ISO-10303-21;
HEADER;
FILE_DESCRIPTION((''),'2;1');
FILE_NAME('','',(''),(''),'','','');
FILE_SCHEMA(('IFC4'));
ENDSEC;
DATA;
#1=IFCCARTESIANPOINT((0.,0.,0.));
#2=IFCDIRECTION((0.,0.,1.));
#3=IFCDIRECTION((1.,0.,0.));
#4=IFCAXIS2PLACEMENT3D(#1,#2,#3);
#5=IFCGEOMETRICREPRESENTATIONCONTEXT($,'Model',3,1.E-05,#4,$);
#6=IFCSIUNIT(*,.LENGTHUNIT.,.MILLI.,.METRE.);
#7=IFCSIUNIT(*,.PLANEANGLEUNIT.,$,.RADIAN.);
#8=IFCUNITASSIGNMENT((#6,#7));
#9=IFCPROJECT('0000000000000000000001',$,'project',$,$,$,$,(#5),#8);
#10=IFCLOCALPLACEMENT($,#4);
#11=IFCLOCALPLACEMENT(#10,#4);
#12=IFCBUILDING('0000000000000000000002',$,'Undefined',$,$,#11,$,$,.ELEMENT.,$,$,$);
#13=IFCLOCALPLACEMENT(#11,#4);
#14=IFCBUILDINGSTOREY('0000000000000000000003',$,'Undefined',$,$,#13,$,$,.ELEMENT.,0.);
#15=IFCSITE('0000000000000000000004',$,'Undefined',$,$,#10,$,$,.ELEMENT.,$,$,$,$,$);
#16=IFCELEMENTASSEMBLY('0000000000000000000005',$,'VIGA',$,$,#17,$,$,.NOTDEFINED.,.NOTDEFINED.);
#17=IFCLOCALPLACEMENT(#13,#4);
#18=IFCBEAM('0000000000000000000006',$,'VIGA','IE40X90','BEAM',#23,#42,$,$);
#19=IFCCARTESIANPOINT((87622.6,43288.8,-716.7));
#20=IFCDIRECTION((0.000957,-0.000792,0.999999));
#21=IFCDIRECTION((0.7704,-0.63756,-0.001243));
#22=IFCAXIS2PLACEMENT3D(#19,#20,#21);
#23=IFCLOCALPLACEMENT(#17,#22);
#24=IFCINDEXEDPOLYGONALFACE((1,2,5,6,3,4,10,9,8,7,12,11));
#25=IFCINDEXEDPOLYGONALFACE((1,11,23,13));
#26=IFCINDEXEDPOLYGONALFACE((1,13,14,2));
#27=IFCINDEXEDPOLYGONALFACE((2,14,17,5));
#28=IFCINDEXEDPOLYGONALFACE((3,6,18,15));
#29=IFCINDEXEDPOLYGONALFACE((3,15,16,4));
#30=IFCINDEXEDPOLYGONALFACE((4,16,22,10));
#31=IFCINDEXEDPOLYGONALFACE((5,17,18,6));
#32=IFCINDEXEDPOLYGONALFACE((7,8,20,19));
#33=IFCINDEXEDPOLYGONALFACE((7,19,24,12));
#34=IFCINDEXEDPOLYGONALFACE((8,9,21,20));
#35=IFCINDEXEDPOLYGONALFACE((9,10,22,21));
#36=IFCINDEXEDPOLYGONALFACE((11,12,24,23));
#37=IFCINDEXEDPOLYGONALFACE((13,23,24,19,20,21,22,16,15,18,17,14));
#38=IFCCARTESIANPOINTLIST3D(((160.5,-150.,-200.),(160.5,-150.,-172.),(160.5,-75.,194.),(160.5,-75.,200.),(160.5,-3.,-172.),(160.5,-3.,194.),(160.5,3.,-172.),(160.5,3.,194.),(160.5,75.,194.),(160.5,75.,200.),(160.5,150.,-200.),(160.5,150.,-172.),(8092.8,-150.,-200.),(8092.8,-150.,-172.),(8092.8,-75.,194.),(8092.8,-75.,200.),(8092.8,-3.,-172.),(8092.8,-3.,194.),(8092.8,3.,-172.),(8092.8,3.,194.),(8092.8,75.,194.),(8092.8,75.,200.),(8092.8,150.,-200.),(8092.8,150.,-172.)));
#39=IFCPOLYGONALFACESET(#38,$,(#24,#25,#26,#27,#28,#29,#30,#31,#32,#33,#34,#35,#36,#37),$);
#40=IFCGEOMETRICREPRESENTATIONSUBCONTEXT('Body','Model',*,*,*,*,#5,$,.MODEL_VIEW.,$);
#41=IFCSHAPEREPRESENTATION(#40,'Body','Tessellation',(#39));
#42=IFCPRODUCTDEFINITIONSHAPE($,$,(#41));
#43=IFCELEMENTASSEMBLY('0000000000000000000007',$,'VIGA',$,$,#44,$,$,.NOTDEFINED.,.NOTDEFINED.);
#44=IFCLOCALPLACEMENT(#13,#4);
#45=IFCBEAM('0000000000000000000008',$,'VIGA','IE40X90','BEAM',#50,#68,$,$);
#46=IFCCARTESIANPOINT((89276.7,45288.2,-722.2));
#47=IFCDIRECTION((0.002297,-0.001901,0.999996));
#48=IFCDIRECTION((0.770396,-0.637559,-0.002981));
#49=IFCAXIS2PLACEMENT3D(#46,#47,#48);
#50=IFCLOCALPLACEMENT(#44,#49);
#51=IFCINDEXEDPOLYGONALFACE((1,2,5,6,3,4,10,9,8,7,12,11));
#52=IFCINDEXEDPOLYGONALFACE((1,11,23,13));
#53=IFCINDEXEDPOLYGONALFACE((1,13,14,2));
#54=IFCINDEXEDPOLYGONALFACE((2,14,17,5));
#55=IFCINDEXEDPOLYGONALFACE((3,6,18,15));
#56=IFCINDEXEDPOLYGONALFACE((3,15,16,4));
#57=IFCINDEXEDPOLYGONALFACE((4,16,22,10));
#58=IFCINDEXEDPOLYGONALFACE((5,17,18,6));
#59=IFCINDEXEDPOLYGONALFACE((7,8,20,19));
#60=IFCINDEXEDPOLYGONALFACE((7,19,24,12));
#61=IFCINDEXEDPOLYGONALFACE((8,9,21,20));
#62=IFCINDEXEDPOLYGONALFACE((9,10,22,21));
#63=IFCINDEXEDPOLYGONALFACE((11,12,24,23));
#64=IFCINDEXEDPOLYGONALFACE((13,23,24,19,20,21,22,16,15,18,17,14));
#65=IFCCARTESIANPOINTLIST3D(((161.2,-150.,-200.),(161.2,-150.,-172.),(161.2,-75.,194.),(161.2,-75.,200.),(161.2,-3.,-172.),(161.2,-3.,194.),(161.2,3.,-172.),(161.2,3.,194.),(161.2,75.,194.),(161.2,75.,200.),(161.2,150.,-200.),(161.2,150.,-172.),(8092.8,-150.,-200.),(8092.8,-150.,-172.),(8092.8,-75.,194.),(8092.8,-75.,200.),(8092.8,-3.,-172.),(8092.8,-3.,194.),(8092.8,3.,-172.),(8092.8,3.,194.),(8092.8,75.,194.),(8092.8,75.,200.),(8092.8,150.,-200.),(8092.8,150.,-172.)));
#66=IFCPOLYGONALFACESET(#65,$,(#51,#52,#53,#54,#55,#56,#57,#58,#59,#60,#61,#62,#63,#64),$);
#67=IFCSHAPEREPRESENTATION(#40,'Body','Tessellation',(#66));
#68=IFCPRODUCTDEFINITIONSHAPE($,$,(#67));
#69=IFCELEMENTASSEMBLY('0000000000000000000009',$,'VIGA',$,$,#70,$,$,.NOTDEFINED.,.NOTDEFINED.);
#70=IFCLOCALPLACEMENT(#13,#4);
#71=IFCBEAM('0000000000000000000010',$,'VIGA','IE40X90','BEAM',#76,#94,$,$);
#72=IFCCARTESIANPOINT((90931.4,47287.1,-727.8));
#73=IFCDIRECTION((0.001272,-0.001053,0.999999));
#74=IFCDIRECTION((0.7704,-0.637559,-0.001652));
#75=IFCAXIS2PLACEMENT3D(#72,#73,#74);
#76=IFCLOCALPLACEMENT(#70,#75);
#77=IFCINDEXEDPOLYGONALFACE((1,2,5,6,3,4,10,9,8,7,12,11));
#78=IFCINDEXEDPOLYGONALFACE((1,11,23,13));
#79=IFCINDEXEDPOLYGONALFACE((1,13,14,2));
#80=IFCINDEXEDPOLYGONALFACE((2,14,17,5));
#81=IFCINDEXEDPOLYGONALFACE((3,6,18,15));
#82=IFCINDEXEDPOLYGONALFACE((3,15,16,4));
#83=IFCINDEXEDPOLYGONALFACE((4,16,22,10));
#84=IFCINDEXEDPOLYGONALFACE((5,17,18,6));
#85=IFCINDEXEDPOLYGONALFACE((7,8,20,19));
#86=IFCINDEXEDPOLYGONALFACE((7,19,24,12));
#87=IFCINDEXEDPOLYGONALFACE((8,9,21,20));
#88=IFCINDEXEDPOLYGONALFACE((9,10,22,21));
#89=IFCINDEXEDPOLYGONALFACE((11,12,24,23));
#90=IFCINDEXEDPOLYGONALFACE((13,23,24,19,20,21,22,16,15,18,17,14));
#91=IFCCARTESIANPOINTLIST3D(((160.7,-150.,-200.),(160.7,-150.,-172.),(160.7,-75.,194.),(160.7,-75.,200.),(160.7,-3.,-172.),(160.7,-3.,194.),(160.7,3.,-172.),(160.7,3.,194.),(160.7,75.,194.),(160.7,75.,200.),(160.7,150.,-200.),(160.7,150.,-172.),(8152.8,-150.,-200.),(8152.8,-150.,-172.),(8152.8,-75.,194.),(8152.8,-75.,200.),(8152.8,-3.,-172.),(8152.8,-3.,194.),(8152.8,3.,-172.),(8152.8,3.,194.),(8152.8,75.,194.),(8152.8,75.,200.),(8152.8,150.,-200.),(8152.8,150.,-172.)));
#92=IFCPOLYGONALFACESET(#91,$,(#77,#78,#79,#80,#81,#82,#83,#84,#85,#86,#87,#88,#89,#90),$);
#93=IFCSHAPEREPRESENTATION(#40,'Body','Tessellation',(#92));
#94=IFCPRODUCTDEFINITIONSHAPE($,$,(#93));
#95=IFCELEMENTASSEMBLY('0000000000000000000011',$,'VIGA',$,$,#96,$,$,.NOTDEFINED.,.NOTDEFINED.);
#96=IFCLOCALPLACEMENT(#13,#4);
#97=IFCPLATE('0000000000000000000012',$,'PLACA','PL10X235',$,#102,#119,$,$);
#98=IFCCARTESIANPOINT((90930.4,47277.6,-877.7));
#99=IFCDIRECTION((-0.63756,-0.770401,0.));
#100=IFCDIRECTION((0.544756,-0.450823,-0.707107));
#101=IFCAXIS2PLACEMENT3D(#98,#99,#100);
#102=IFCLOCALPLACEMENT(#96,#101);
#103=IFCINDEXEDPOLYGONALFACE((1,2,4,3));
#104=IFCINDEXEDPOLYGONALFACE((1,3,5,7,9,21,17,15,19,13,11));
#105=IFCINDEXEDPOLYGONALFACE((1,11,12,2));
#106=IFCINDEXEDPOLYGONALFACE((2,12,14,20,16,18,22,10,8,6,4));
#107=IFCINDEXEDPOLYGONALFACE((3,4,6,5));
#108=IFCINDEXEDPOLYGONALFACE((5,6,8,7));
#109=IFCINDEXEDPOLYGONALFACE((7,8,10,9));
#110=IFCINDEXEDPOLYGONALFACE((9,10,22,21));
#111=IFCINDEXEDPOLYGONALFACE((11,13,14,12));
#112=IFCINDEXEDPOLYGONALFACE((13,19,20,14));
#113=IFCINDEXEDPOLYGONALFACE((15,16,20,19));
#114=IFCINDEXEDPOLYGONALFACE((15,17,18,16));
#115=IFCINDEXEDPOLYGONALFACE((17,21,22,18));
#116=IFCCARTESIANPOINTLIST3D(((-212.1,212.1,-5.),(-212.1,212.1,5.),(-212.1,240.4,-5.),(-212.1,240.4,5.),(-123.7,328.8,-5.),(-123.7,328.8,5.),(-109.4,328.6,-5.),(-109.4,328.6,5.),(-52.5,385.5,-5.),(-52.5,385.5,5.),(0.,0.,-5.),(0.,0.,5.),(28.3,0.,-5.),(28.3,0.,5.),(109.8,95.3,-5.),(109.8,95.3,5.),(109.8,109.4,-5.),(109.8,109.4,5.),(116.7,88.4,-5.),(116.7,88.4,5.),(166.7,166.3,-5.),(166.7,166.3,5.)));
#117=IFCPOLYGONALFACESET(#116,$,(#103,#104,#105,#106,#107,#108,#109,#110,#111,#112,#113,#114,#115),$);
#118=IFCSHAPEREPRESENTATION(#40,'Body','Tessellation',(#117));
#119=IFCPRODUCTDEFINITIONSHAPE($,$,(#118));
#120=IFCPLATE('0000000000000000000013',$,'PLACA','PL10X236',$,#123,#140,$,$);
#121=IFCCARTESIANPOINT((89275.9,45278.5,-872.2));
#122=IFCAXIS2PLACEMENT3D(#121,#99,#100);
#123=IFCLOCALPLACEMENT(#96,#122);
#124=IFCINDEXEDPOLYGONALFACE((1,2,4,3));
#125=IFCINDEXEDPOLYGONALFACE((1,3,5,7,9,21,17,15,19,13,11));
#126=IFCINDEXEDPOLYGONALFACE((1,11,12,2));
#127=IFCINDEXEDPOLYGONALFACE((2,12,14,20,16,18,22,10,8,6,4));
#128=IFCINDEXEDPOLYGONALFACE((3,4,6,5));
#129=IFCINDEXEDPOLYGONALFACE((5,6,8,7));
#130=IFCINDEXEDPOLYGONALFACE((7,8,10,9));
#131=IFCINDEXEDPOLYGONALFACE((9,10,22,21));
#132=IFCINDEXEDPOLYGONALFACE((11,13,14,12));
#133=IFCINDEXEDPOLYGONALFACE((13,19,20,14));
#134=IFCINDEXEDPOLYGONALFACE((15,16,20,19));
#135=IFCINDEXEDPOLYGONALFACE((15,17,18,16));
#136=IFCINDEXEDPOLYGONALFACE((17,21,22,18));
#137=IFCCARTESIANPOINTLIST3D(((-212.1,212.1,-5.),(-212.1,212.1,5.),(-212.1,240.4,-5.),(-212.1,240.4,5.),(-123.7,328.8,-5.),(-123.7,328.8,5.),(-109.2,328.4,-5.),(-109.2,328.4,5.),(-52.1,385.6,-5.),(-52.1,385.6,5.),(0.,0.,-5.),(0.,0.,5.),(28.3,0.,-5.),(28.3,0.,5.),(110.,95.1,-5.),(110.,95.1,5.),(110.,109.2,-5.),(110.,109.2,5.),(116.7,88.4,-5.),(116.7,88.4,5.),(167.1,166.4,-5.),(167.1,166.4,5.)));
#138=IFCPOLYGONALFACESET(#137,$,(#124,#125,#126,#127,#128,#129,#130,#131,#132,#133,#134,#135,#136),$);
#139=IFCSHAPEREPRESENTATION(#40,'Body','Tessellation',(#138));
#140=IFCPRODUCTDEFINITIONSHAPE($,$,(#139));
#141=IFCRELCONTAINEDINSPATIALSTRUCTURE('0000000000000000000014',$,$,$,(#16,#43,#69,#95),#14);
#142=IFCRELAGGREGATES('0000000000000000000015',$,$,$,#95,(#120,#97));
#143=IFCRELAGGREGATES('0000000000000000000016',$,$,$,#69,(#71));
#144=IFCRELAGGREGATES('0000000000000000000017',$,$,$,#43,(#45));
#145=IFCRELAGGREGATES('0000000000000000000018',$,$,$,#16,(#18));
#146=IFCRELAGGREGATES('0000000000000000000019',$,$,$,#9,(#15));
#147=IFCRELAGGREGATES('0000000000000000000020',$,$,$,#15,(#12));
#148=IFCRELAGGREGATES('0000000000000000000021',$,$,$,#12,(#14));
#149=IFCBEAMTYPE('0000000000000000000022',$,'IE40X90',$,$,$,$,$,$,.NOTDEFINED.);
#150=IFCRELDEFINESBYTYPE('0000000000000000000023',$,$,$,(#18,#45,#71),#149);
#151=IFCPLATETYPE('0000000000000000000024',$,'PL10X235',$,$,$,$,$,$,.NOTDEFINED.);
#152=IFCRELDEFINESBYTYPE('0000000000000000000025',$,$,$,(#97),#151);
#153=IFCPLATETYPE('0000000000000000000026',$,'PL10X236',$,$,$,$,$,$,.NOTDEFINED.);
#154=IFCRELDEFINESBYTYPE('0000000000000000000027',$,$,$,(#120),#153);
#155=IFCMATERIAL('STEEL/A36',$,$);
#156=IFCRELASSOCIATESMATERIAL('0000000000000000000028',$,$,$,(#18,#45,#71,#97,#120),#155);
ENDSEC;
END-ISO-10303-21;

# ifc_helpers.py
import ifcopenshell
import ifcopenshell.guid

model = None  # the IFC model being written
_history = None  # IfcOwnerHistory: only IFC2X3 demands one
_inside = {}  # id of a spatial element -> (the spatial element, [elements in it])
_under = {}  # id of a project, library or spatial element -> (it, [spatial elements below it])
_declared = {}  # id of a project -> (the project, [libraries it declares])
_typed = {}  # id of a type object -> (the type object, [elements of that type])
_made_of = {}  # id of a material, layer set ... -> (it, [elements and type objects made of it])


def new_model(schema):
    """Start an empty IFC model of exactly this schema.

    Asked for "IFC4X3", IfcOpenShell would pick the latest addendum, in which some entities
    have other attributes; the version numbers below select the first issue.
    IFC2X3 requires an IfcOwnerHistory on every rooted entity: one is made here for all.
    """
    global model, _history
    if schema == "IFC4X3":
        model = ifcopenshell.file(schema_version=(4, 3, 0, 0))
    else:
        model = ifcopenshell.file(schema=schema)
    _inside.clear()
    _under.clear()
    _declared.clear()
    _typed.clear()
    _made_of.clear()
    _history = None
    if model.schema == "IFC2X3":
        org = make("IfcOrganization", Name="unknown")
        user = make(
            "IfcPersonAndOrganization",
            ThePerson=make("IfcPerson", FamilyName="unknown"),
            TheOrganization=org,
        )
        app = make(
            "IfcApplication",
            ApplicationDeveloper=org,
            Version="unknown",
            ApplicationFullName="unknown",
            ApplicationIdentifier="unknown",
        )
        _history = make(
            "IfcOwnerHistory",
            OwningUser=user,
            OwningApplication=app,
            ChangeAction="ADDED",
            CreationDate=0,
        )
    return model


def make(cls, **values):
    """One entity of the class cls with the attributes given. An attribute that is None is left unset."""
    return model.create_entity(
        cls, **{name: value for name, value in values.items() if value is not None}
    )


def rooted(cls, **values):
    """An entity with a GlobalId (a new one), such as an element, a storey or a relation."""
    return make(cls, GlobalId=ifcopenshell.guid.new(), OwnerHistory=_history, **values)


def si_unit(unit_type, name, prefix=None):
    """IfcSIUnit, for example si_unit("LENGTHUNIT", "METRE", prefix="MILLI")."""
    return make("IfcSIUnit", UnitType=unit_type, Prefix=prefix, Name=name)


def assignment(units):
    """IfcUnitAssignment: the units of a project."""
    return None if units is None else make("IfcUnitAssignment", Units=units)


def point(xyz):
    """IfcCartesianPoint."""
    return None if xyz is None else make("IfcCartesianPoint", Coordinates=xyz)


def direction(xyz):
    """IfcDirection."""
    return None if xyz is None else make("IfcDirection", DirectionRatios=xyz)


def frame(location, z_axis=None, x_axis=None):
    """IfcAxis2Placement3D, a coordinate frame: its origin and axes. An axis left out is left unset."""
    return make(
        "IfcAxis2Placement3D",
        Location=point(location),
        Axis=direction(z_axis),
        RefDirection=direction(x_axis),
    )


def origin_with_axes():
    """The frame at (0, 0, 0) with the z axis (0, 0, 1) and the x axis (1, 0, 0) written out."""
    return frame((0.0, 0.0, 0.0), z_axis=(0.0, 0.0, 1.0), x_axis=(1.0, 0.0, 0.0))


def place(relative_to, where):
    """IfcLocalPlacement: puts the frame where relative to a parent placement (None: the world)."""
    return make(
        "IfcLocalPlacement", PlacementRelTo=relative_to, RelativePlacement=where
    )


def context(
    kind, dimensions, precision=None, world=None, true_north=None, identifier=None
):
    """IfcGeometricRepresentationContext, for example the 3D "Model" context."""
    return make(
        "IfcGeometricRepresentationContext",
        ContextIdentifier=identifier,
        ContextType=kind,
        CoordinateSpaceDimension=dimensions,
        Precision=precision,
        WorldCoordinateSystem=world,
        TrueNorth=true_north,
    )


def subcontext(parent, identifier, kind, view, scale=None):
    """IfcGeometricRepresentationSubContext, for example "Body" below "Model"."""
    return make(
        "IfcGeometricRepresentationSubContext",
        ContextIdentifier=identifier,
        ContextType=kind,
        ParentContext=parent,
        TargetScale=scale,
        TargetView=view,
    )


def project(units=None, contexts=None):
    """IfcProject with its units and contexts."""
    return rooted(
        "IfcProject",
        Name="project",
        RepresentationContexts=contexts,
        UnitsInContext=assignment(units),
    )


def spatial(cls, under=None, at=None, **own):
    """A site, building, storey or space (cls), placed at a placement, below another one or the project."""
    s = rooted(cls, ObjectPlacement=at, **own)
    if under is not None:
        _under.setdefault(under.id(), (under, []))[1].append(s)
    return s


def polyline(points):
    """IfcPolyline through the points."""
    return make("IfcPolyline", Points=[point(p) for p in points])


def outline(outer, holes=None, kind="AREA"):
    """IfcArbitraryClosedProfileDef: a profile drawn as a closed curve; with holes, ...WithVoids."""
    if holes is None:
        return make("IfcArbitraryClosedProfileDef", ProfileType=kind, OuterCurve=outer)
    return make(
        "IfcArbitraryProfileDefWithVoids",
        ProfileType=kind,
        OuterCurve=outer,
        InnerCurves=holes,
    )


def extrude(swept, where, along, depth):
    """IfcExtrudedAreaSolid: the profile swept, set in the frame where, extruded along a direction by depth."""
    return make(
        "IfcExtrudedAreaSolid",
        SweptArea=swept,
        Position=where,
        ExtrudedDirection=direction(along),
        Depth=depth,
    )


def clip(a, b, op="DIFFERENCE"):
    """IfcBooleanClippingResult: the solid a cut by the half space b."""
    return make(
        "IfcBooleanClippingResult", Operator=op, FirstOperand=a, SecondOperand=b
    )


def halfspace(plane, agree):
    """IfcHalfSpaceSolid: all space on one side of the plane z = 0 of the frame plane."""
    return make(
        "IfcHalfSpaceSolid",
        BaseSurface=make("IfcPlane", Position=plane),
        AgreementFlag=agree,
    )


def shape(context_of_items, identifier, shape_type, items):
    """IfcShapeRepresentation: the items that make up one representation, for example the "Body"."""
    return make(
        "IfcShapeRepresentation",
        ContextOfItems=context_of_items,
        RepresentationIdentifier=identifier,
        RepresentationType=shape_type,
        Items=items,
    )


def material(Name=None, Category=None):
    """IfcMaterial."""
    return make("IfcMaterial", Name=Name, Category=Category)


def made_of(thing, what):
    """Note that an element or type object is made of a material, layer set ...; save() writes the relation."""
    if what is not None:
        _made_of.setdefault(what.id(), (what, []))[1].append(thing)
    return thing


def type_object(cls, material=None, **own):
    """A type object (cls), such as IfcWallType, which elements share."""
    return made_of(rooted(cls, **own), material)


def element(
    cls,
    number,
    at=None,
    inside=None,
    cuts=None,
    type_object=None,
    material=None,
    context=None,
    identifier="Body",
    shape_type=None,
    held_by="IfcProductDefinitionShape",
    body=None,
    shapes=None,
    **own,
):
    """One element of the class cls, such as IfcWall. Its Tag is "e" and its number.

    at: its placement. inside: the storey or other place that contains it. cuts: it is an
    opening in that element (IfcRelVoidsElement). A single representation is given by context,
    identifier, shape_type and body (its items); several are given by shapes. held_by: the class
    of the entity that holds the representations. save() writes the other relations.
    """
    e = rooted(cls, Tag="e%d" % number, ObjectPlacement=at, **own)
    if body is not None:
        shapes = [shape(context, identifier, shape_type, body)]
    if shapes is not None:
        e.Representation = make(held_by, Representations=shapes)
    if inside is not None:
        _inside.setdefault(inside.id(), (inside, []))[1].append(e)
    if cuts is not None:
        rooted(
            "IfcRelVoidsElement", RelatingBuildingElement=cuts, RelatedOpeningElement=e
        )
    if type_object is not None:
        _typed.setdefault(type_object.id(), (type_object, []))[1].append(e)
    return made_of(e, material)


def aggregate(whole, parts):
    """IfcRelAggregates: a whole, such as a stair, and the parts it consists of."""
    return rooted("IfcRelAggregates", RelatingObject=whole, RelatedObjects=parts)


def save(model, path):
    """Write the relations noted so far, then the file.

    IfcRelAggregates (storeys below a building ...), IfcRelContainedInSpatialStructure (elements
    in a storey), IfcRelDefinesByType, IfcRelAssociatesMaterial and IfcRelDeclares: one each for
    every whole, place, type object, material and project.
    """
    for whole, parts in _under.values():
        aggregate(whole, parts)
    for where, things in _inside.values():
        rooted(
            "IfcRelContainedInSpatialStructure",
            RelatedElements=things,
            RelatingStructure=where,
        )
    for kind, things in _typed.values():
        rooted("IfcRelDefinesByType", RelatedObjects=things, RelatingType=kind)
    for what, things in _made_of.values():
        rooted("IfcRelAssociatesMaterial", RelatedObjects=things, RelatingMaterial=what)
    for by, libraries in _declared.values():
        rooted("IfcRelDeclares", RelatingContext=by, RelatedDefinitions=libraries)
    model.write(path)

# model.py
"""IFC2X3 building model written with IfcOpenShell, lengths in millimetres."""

from ifc_helpers import new_model, si_unit, frame, origin_with_axes, place, context, subcontext, project, spatial, polyline, outline, extrude, clip, halfspace, material, type_object, element, aggregate, save


model = new_model("IFC2X3")

# Units and contexts
model_context = context("Model", 3, precision=1e-05, world=origin_with_axes())
body_context = subcontext(model_context, "Body", "Model", "MODEL_VIEW")
ifc_project = project(units=[si_unit("LENGTHUNIT", "METRE", prefix="MILLI"), si_unit("PLANEANGLEUNIT", "RADIAN")], contexts=[model_context])

# Site, building, storey
site_placement = place(None, origin_with_axes())
site = spatial("IfcSite", under=ifc_project, at=site_placement, Name="Undefined", CompositionType="ELEMENT")
building_placement = place(site_placement, origin_with_axes())
building = spatial("IfcBuilding", under=site, at=building_placement, Name="Undefined", CompositionType="ELEMENT")
storey_placement = place(building_placement, origin_with_axes())
storey = spatial("IfcBuildingStorey", under=building, at=storey_placement, Name="Undefined", CompositionType="ELEMENT", Elevation=0.0)

# Element assemblies, beams
ifc_material_1 = material(Name="STEEL/A36")
assembly_1_placement = place(storey_placement, origin_with_axes())
assembly_1 = element("IfcElementAssembly", 1, at=assembly_1_placement, inside=storey, Name="VIGA", AssemblyPlace="NOTDEFINED", PredefinedType="NOTDEFINED")
beam_type_1 = type_object("IfcBeamType", Name="IE40X90", PredefinedType="NOTDEFINED")
beam_1_placement = place(assembly_1_placement, frame((87622.6, 43288.8, -716.7), z_axis=(0.000957, -0.000792, 0.999999), x_axis=(0.7704, -0.63756, -0.001243)))
beam_1 = element("IfcBeam", 2, at=beam_1_placement, type_object=beam_type_1, material=ifc_material_1, Name="VIGA", Description="IE40X90", ObjectType="BEAM", context=body_context, shape_type="Clipping", body=[
    clip(clip(extrude(outline(polyline([(3.0, 194.0), (3.0, -172.0), (150.0, -172.0), (150.0, -200.0), (-150.0, -200.0), (-150.0, -172.0), (-3.0, -172.0), (-3.0, 194.0), (-75.0, 194.0), (-75.0, 200.0), (75.0, 200.0), (75.0, 194.0), (3.0, 194.0)])), frame((8391.0, 0.0, 0.0), z_axis=(-1.0, 0.0, 0.0), x_axis=(0.0, -1.0, 0.0)), (0.0, 0.0, 1.0), 8528.7), halfspace(frame((8092.8, 0.0, 200.0), z_axis=(1.0, 0.0, 0.0), x_axis=(0.0, 1.0, 0.0)), False)), halfspace(frame((160.5, 0.0, -200.0), z_axis=(1.0, 0.0, 0.0), x_axis=(0.0, -1.0, 0.0)), True)),
])
assembly_2_placement = place(storey_placement, origin_with_axes())
assembly_2 = element("IfcElementAssembly", 3, at=assembly_2_placement, inside=storey, Name="VIGA", AssemblyPlace="NOTDEFINED", PredefinedType="NOTDEFINED")
beam_2_placement = place(assembly_2_placement, frame((89276.7, 45288.2, -722.2), z_axis=(0.002297, -0.001901, 0.999996), x_axis=(0.770396, -0.637559, -0.002981)))
beam_2 = element("IfcBeam", 4, at=beam_2_placement, type_object=beam_type_1, material=ifc_material_1, Name="VIGA", Description="IE40X90", ObjectType="BEAM", context=body_context, shape_type="Clipping", body=[
    clip(clip(extrude(outline(polyline([(3.0, 194.0), (3.0, -172.0), (150.0, -172.0), (150.0, -200.0), (-150.0, -200.0), (-150.0, -172.0), (-3.0, -172.0), (-3.0, 194.0), (-75.0, 194.0), (-75.0, 200.0), (75.0, 200.0), (75.0, 194.0), (3.0, 194.0)])), frame((8391.8, 0.0, 0.0), z_axis=(-1.0, 0.0, 0.0), x_axis=(0.0, -1.0, 0.0)), (0.0, 0.0, 1.0), 8529.5), halfspace(frame((8092.8, 0.0, 200.0), z_axis=(1.0, 0.0, 0.0), x_axis=(0.0, 1.0, 0.0)), False)), halfspace(frame((161.2, 0.0, -200.0), z_axis=(1.0, 0.0, 0.0), x_axis=(0.0, -1.0, 0.0)), True)),
])
assembly_3_placement = place(storey_placement, origin_with_axes())
assembly_3 = element("IfcElementAssembly", 5, at=assembly_3_placement, inside=storey, Name="VIGA", AssemblyPlace="NOTDEFINED", PredefinedType="NOTDEFINED")
beam_3_placement = place(assembly_3_placement, frame((90931.4, 47287.1, -727.8), z_axis=(0.001272, -0.001053, 0.999999), x_axis=(0.7704, -0.637559, -0.001652)))
beam_3 = element("IfcBeam", 6, at=beam_3_placement, type_object=beam_type_1, material=ifc_material_1, Name="VIGA", Description="IE40X90", ObjectType="BEAM", context=body_context, shape_type="Clipping", body=[
    clip(clip(extrude(outline(polyline([(3.0, 194.0), (3.0, -172.0), (150.0, -172.0), (150.0, -200.0), (-150.0, -200.0), (-150.0, -172.0), (-3.0, -172.0), (-3.0, 194.0), (-75.0, 194.0), (-75.0, 200.0), (75.0, 200.0), (75.0, 194.0), (3.0, 194.0)])), frame((8451.1, 0.0, 0.0), z_axis=(-1.0, 0.0, 0.0), x_axis=(0.0, -1.0, 0.0)), (0.0, 0.0, 1.0), 8588.8), halfspace(frame((8152.8, 0.0, 200.0), z_axis=(1.0, 0.0, -0.000117), x_axis=(0.0, 1.0, 0.0)), False)), halfspace(frame((160.7, 0.0, -200.0), z_axis=(1.0, 0.0, 0.0), x_axis=(0.0, -1.0, 0.0)), True)),
])

# Element assembly
assembly_4_placement = place(storey_placement, origin_with_axes())
assembly_4 = element("IfcElementAssembly", 7, at=assembly_4_placement, inside=storey, Name="VIGA", AssemblyPlace="NOTDEFINED", PredefinedType="NOTDEFINED")

# Plates
plate_type_1 = type_object("IfcPlateType", Name="PL10X235", PredefinedType="NOTDEFINED")
plate_1_placement = place(assembly_4_placement, frame((90930.4, 47277.6, -877.7), z_axis=(-0.63756, -0.770401, 0.0), x_axis=(0.544756, -0.450823, -0.707107)))
plate_1 = element("IfcPlate", 8, at=plate_1_placement, type_object=plate_type_1, material=ifc_material_1, Name="PLACA", Description="PL10X235", context=body_context, shape_type="SweptSolid", body=[
    extrude(outline(polyline([(0.0, 0.0), (28.3, 0.0), (116.7, 88.4), (109.8, 95.3), (109.8, 109.4), (166.7, 166.3), (-52.5, 385.5), (-109.4, 328.6), (-123.7, 328.8), (-212.1, 240.4), (-212.1, 212.1), (0.0, 0.0)])), frame((0.0, 0.0, -5.0), z_axis=(0.0, 0.0, 1.0), x_axis=(1.0, 0.0, 0.0)), (0.0, 0.0, 1.0), 10.0),
])
plate_type_2 = type_object("IfcPlateType", Name="PL10X236", PredefinedType="NOTDEFINED")
plate_2_placement = place(assembly_4_placement, frame((89275.9, 45278.5, -872.2), z_axis=(-0.63756, -0.770401, 0.0), x_axis=(0.544756, -0.450823, -0.707107)))
plate_2 = element("IfcPlate", 9, at=plate_2_placement, type_object=plate_type_2, material=ifc_material_1, Name="PLACA", Description="PL10X236", context=body_context, shape_type="SweptSolid", body=[
    extrude(outline(polyline([(0.0, 0.0), (28.3, 0.0), (116.7, 88.4), (110.0, 95.1), (110.0, 109.2), (167.1, 166.4), (-52.1, 385.6), (-109.2, 328.4), (-123.7, 328.8), (-212.1, 240.4), (-212.1, 212.1), (0.0, 0.0)])), frame((0.0, 0.0, -5.0), z_axis=(0.0, 0.0, 1.0), x_axis=(1.0, 0.0, 0.0)), (0.0, 0.0, 1.0), 10.0),
])
aggregate(assembly_4, [plate_2, plate_1])

aggregate(assembly_3, [beam_3])
aggregate(assembly_2, [beam_2])
aggregate(assembly_1, [beam_1])

save(model, "model.ifc")
